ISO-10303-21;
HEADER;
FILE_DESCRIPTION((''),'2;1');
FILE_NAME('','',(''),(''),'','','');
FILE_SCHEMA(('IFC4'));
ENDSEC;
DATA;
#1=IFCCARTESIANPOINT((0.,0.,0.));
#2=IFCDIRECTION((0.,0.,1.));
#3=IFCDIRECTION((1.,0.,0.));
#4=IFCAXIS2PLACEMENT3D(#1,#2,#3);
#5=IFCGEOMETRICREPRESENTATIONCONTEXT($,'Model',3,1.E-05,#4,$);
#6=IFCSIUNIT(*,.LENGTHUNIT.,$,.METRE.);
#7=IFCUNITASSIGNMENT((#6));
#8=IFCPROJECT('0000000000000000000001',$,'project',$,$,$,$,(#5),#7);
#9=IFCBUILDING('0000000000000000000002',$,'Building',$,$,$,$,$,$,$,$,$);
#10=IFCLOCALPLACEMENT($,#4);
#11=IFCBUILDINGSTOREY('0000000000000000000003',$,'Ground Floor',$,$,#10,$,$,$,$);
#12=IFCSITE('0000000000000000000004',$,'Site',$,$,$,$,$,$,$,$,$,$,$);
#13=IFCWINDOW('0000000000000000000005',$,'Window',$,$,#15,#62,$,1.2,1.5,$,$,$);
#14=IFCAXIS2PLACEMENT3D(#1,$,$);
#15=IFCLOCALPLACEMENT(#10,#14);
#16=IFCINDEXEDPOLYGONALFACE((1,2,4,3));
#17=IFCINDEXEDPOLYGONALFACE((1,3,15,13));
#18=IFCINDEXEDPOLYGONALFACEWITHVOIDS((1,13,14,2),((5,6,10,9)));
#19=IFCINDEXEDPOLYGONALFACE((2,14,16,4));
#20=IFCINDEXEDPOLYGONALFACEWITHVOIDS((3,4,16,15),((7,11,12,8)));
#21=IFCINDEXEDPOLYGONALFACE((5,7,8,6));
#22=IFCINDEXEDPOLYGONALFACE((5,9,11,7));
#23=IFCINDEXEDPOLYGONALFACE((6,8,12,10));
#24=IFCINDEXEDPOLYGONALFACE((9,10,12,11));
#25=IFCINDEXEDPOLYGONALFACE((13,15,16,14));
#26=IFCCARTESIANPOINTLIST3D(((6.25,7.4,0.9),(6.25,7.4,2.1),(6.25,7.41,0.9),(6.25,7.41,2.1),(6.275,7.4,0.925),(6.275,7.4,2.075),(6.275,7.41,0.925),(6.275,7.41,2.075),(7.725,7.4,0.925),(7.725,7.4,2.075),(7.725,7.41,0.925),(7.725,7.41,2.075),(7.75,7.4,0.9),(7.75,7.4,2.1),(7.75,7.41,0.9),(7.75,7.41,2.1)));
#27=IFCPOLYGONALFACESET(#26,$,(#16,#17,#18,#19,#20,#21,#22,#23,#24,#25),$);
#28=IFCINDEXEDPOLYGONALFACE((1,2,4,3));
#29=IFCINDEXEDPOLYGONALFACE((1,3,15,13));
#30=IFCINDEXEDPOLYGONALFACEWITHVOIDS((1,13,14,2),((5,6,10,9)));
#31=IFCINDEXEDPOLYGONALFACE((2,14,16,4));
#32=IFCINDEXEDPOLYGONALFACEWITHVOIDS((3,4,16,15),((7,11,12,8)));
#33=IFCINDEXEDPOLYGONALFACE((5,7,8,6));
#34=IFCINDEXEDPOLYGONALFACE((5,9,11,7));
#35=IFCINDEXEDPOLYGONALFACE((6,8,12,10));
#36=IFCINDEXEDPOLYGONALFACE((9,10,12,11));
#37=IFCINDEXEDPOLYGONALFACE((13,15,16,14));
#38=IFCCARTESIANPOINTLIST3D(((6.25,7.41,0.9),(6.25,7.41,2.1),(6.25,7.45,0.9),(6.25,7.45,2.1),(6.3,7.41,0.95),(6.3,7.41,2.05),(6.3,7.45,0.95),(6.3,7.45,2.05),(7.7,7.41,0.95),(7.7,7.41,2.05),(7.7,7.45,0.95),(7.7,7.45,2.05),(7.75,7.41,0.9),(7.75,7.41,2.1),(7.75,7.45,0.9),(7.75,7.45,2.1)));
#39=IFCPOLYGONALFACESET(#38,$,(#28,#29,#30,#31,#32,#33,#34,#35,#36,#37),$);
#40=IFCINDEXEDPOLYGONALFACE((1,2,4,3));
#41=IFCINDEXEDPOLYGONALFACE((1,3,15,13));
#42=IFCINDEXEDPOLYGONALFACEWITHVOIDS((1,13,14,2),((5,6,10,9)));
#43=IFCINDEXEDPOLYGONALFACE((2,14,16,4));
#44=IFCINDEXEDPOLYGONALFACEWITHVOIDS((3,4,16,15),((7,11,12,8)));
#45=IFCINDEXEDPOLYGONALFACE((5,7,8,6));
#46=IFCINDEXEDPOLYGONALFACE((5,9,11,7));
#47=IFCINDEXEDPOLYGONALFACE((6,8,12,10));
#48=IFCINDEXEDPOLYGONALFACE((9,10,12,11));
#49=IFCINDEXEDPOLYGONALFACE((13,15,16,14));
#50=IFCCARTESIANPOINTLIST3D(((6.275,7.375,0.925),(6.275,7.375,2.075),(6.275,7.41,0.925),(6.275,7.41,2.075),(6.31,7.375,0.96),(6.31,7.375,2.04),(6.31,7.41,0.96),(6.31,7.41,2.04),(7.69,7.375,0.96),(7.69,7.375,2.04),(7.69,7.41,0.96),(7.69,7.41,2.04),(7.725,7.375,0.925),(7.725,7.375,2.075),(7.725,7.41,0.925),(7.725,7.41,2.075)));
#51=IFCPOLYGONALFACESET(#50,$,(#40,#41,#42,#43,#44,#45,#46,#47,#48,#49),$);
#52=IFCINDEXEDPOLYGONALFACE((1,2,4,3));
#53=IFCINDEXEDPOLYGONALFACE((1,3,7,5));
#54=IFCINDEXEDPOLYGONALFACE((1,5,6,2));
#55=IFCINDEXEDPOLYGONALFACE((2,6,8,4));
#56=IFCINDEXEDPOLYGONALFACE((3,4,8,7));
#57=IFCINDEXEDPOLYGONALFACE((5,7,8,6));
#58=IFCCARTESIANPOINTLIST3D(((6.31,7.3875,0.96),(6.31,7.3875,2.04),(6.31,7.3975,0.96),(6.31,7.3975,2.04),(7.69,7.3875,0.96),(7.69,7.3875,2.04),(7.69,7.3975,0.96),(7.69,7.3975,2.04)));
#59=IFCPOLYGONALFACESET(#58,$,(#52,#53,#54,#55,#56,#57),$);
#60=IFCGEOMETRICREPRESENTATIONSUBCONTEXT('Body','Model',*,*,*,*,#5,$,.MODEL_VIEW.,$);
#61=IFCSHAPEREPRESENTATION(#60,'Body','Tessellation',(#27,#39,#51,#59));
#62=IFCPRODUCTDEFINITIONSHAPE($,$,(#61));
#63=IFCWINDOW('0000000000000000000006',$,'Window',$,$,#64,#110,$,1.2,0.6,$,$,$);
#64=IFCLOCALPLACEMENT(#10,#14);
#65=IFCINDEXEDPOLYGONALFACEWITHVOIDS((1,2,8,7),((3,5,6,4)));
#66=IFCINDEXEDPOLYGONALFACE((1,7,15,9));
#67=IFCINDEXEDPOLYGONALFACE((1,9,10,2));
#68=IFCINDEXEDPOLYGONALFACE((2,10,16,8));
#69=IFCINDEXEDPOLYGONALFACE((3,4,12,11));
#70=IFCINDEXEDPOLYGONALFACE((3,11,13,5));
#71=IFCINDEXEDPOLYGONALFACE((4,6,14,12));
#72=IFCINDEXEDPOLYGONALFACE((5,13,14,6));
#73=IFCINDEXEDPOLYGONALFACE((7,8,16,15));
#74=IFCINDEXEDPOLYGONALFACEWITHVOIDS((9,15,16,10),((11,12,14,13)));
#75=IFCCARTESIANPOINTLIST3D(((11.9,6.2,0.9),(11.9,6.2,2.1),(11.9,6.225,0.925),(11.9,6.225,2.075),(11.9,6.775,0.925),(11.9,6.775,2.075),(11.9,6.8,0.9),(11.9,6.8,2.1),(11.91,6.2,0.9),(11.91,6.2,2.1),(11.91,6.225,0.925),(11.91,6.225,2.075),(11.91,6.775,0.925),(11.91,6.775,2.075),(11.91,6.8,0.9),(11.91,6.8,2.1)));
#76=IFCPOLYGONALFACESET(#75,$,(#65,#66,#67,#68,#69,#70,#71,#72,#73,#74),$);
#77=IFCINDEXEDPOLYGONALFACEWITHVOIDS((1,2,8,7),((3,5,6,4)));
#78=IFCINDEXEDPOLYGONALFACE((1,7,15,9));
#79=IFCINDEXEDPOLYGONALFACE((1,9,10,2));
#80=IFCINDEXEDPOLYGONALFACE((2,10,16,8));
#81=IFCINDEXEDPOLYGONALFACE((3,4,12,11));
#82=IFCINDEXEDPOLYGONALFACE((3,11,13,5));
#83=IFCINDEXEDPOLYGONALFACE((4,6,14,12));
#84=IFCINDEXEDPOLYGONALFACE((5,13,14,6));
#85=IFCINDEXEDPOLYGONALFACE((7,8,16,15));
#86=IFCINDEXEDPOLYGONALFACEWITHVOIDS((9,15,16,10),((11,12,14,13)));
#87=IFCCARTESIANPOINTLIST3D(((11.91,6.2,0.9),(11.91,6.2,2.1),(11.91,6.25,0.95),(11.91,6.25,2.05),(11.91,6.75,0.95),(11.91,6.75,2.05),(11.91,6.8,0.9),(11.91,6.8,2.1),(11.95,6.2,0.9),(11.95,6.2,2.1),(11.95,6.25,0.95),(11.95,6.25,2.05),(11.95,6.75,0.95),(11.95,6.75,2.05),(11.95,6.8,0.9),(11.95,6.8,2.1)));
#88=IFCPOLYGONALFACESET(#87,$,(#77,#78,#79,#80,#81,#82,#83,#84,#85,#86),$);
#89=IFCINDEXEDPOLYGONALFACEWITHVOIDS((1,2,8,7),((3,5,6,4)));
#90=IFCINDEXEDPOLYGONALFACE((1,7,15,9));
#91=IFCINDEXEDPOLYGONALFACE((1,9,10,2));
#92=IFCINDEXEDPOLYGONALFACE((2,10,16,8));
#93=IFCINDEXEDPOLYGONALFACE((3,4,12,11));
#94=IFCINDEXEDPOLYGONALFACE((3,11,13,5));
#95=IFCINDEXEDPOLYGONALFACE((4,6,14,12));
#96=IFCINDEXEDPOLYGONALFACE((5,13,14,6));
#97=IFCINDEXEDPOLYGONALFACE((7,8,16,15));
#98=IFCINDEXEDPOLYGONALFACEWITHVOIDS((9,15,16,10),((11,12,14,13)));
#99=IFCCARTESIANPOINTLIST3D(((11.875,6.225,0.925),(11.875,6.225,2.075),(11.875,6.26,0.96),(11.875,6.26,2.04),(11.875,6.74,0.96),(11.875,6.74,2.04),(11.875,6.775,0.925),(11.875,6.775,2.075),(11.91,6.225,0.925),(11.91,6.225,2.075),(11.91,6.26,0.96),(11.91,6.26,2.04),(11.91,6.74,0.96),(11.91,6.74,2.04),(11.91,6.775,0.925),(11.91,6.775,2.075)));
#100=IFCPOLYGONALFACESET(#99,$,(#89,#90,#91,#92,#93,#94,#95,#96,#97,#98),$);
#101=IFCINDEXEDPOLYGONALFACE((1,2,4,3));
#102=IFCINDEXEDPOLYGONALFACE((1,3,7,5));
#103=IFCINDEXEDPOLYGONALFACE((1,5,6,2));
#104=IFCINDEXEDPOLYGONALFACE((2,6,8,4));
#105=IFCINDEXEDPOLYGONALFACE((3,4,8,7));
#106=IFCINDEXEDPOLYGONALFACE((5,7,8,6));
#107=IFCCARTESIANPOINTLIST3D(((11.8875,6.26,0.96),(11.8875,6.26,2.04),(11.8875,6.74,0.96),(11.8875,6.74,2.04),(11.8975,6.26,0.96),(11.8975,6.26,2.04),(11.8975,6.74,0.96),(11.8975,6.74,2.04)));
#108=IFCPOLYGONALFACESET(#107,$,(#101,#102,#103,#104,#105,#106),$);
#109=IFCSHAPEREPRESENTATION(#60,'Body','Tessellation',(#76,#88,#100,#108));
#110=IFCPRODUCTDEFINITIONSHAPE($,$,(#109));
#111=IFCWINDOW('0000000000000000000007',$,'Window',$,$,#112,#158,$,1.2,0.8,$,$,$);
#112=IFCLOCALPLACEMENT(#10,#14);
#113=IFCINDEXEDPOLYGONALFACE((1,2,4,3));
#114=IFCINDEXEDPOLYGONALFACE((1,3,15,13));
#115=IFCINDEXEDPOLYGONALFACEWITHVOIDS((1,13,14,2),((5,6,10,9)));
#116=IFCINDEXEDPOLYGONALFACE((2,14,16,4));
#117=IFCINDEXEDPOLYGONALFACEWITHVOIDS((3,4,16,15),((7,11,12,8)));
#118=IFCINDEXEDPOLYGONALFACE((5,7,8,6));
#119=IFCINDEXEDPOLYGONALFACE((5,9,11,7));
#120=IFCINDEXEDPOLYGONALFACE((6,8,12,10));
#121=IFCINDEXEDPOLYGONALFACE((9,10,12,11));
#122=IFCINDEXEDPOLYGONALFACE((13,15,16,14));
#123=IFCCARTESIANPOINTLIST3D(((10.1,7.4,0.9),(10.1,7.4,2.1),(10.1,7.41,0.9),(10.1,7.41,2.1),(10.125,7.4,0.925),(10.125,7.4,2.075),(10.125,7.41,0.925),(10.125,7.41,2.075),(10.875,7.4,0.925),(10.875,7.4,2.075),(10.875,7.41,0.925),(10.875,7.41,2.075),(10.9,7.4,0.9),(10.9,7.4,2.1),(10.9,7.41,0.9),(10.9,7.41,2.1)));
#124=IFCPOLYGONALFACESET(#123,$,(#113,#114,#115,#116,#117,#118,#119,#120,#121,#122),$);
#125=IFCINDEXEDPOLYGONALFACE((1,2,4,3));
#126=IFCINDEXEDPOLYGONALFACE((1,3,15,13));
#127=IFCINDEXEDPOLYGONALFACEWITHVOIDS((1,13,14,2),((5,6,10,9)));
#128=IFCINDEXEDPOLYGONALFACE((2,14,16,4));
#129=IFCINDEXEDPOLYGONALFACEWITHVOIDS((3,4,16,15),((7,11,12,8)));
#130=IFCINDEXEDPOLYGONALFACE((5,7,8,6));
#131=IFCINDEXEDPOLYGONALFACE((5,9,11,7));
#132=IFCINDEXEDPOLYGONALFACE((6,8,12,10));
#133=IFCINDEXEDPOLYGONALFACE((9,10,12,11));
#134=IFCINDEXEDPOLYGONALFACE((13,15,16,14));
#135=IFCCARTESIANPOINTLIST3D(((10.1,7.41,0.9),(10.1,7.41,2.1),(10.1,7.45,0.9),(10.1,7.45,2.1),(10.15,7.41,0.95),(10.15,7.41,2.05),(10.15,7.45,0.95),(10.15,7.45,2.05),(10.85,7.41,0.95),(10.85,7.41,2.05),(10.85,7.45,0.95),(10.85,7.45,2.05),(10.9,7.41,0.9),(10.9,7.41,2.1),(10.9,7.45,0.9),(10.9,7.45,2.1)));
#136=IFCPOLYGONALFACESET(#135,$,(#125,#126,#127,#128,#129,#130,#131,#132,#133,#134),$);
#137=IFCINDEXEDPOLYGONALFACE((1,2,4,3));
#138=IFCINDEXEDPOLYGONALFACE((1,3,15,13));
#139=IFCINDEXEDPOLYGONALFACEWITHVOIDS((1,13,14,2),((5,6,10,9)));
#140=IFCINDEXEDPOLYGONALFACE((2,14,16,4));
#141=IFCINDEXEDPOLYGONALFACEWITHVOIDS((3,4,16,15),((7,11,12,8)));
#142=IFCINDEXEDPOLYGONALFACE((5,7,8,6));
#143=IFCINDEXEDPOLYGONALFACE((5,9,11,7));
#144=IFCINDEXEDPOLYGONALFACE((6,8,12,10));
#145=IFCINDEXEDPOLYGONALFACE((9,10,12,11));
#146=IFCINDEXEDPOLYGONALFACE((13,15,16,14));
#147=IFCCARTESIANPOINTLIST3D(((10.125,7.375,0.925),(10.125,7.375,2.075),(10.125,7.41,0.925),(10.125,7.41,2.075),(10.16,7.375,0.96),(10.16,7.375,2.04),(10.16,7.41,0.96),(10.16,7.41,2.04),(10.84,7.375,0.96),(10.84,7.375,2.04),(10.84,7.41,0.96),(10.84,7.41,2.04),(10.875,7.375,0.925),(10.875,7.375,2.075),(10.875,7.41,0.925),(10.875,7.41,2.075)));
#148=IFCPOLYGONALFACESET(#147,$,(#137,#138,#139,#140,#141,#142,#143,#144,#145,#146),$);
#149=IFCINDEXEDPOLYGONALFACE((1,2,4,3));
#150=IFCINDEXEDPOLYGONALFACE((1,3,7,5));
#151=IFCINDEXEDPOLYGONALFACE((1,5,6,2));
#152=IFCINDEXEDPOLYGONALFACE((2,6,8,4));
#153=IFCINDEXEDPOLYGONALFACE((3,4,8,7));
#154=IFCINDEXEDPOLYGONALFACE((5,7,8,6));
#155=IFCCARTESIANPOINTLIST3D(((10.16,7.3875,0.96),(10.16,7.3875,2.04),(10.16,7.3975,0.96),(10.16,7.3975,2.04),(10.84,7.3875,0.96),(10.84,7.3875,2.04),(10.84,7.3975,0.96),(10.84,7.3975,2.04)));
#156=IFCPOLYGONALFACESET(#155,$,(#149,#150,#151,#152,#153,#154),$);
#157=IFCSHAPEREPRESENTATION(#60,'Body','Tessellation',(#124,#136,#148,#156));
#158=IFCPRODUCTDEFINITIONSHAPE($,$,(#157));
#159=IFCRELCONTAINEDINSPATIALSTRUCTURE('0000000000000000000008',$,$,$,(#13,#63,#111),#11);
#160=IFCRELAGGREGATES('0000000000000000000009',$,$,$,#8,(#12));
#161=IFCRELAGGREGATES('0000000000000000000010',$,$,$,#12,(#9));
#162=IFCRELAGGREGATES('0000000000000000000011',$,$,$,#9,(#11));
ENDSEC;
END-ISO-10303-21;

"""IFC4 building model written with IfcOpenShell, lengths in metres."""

from ifc_helpers import new_model, si_unit, frame, origin_with_axes, place, context, subcontext, project, spatial, line, indexed_curve, outline, extrude, element, save


model = new_model("IFC4")

# Units and contexts
model_context = context("Model", 3, precision=1e-05, world=origin_with_axes())
body_context = subcontext(model_context, "Body", "Model", "MODEL_VIEW")
ifc_project = project(units=[si_unit("LENGTHUNIT", "METRE")], contexts=[model_context])

# Site, building, storey
site = spatial("IfcSite", under=ifc_project, Name="Site")
building = spatial("IfcBuilding", under=site, Name="Building")
storey_placement = place(None, origin_with_axes())
storey = spatial("IfcBuildingStorey", under=building, at=storey_placement, Name="Ground Floor")

# Windows
for number, where, z_axis, x_axis, name in (
    (1, (7.75, 7.5, 0.9), (0.0, 0.0, 1.0), (-1.0, 0.0, 0.0), "Window"),
):
    element("IfcWindow", number, at=place(storey_placement, frame(where, z_axis=z_axis, x_axis=x_axis)), inside=storey, Name=name, OverallHeight=1.2, OverallWidth=1.5, context=body_context, shape_type="SweptSolid", body=[
        extrude(outline(indexed_curve([(0.0, 0.0), (1.5, 0.0), (1.5, 1.2), (0.0, 1.2)], segments=[line(1, 2, 3, 4, 1)]), holes=[indexed_curve([(0.025, 0.025), (1.475, 0.025), (1.475, 1.175), (0.025, 1.175)], segments=[line(1, 2, 3, 4, 1)])]), frame((0.0, 0.09, 0.0), z_axis=(0.0, -1.0, 0.0), x_axis=(1.0, 0.0, 0.0)), (0.0, 0.0, -1.0), 0.01),
        extrude(outline(indexed_curve([(0.0, 0.0), (1.5, 0.0), (1.5, 1.2), (0.0, 1.2)], segments=[line(1, 2, 3, 4, 1)]), holes=[indexed_curve([(0.05, 0.05), (1.45, 0.05), (1.45, 1.15), (0.05, 1.15)], segments=[line(1, 2, 3, 4, 1)])]), frame((0.0, 0.05, 0.0), z_axis=(0.0, -1.0, 0.0), x_axis=(1.0, 0.0, 0.0)), (0.0, 0.0, -1.0), 0.04),
        extrude(outline(indexed_curve([(0.0, 0.0), (1.45, 0.0), (1.45, 1.15), (0.0, 1.15)], segments=[line(1, 2, 3, 4, 1)]), holes=[indexed_curve([(0.035, 0.035), (1.415, 0.035), (1.415, 1.115), (0.035, 1.115)], segments=[line(1, 2, 3, 4, 1)])]), frame((0.025, 0.09, 0.025), z_axis=(0.0, -1.0, 0.0), x_axis=(1.0, 0.0, 0.0)), (0.0, 0.0, -1.0), 0.035),
        extrude(outline(indexed_curve([(0.035, 0.035), (1.415, 0.035), (1.415, 1.115), (0.035, 1.115)], segments=[line(1, 2, 3, 4, 1)])), frame((0.025, 0.1025, 0.025), z_axis=(0.0, -1.0, 0.0), x_axis=(1.0, 0.0, 0.0)), (0.0, 0.0, -1.0), 0.01),
    ])
window_1_placement = place(storey_placement, frame((12.0, 6.2, 0.9), z_axis=(0.0, 0.0, 1.0), x_axis=(0.0, 1.0, 0.0)))
element("IfcWindow", 2, at=window_1_placement, inside=storey, Name="Window", OverallHeight=1.2, OverallWidth=0.6, context=body_context, shape_type="SweptSolid", body=[
    extrude(outline(indexed_curve([(0.0, 0.0), (0.6, 0.0), (0.6, 1.2), (0.0, 1.2)], segments=[line(1, 2, 3, 4, 1)]), holes=[indexed_curve([(0.025, 0.025), (0.575, 0.025), (0.575, 1.175), (0.025, 1.175)], segments=[line(1, 2, 3, 4, 1)])]), frame((0.0, 0.09, 0.0), z_axis=(0.0, -1.0, 0.0), x_axis=(1.0, 0.0, 0.0)), (0.0, 0.0, -1.0), 0.01),
    extrude(outline(indexed_curve([(0.0, 0.0), (0.6, 0.0), (0.6, 1.2), (0.0, 1.2)], segments=[line(1, 2, 3, 4, 1)]), holes=[indexed_curve([(0.05, 0.05), (0.55, 0.05), (0.55, 1.15), (0.05, 1.15)], segments=[line(1, 2, 3, 4, 1)])]), frame((0.0, 0.05, 0.0), z_axis=(0.0, -1.0, 0.0), x_axis=(1.0, 0.0, 0.0)), (0.0, 0.0, -1.0), 0.04),
    extrude(outline(indexed_curve([(0.0, 0.0), (0.55, 0.0), (0.55, 1.15), (0.0, 1.15)], segments=[line(1, 2, 3, 4, 1)]), holes=[indexed_curve([(0.035, 0.035), (0.515, 0.035), (0.515, 1.115), (0.035, 1.115)], segments=[line(1, 2, 3, 4, 1)])]), frame((0.025, 0.09, 0.025), z_axis=(0.0, -1.0, 0.0), x_axis=(1.0, 0.0, 0.0)), (0.0, 0.0, -1.0), 0.035),
    extrude(outline(indexed_curve([(0.035, 0.035), (0.515, 0.035), (0.515, 1.115), (0.035, 1.115)], segments=[line(1, 2, 3, 4, 1)])), frame((0.025, 0.1025, 0.025), z_axis=(0.0, -1.0, 0.0), x_axis=(1.0, 0.0, 0.0)), (0.0, 0.0, -1.0), 0.01),
])
window_2_placement = place(storey_placement, frame((10.9, 7.5, 0.9), z_axis=(0.0, 0.0, 1.0), x_axis=(-1.0, 0.0, 0.0)))
element("IfcWindow", 3, at=window_2_placement, inside=storey, Name="Window", OverallHeight=1.2, OverallWidth=0.8, context=body_context, shape_type="SweptSolid", body=[
    extrude(outline(indexed_curve([(0.0, 0.0), (0.8, 0.0), (0.8, 1.2), (0.0, 1.2)], segments=[line(1, 2, 3, 4, 1)]), holes=[indexed_curve([(0.025, 0.025), (0.775, 0.025), (0.775, 1.175), (0.025, 1.175)], segments=[line(1, 2, 3, 4, 1)])]), frame((0.0, 0.09, 0.0), z_axis=(0.0, -1.0, 0.0), x_axis=(1.0, 0.0, 0.0)), (0.0, 0.0, -1.0), 0.01),
    extrude(outline(indexed_curve([(0.0, 0.0), (0.8, 0.0), (0.8, 1.2), (0.0, 1.2)], segments=[line(1, 2, 3, 4, 1)]), holes=[indexed_curve([(0.05, 0.05), (0.75, 0.05), (0.75, 1.15), (0.05, 1.15)], segments=[line(1, 2, 3, 4, 1)])]), frame((0.0, 0.05, 0.0), z_axis=(0.0, -1.0, 0.0), x_axis=(1.0, 0.0, 0.0)), (0.0, 0.0, -1.0), 0.04),
    extrude(outline(indexed_curve([(0.0, 0.0), (0.75, 0.0), (0.75, 1.15), (0.0, 1.15)], segments=[line(1, 2, 3, 4, 1)]), holes=[indexed_curve([(0.035, 0.035), (0.715, 0.035), (0.715, 1.115), (0.035, 1.115)], segments=[line(1, 2, 3, 4, 1)])]), frame((0.025, 0.09, 0.025), z_axis=(0.0, -1.0, 0.0), x_axis=(1.0, 0.0, 0.0)), (0.0, 0.0, -1.0), 0.035),
    extrude(outline(indexed_curve([(0.035, 0.035), (0.715, 0.035), (0.715, 1.115), (0.035, 1.115)], segments=[line(1, 2, 3, 4, 1)])), frame((0.025, 0.1025, 0.025), z_axis=(0.0, -1.0, 0.0), x_axis=(1.0, 0.0, 0.0)), (0.0, 0.0, -1.0), 0.01),
])

save(model, "model.ifc")
